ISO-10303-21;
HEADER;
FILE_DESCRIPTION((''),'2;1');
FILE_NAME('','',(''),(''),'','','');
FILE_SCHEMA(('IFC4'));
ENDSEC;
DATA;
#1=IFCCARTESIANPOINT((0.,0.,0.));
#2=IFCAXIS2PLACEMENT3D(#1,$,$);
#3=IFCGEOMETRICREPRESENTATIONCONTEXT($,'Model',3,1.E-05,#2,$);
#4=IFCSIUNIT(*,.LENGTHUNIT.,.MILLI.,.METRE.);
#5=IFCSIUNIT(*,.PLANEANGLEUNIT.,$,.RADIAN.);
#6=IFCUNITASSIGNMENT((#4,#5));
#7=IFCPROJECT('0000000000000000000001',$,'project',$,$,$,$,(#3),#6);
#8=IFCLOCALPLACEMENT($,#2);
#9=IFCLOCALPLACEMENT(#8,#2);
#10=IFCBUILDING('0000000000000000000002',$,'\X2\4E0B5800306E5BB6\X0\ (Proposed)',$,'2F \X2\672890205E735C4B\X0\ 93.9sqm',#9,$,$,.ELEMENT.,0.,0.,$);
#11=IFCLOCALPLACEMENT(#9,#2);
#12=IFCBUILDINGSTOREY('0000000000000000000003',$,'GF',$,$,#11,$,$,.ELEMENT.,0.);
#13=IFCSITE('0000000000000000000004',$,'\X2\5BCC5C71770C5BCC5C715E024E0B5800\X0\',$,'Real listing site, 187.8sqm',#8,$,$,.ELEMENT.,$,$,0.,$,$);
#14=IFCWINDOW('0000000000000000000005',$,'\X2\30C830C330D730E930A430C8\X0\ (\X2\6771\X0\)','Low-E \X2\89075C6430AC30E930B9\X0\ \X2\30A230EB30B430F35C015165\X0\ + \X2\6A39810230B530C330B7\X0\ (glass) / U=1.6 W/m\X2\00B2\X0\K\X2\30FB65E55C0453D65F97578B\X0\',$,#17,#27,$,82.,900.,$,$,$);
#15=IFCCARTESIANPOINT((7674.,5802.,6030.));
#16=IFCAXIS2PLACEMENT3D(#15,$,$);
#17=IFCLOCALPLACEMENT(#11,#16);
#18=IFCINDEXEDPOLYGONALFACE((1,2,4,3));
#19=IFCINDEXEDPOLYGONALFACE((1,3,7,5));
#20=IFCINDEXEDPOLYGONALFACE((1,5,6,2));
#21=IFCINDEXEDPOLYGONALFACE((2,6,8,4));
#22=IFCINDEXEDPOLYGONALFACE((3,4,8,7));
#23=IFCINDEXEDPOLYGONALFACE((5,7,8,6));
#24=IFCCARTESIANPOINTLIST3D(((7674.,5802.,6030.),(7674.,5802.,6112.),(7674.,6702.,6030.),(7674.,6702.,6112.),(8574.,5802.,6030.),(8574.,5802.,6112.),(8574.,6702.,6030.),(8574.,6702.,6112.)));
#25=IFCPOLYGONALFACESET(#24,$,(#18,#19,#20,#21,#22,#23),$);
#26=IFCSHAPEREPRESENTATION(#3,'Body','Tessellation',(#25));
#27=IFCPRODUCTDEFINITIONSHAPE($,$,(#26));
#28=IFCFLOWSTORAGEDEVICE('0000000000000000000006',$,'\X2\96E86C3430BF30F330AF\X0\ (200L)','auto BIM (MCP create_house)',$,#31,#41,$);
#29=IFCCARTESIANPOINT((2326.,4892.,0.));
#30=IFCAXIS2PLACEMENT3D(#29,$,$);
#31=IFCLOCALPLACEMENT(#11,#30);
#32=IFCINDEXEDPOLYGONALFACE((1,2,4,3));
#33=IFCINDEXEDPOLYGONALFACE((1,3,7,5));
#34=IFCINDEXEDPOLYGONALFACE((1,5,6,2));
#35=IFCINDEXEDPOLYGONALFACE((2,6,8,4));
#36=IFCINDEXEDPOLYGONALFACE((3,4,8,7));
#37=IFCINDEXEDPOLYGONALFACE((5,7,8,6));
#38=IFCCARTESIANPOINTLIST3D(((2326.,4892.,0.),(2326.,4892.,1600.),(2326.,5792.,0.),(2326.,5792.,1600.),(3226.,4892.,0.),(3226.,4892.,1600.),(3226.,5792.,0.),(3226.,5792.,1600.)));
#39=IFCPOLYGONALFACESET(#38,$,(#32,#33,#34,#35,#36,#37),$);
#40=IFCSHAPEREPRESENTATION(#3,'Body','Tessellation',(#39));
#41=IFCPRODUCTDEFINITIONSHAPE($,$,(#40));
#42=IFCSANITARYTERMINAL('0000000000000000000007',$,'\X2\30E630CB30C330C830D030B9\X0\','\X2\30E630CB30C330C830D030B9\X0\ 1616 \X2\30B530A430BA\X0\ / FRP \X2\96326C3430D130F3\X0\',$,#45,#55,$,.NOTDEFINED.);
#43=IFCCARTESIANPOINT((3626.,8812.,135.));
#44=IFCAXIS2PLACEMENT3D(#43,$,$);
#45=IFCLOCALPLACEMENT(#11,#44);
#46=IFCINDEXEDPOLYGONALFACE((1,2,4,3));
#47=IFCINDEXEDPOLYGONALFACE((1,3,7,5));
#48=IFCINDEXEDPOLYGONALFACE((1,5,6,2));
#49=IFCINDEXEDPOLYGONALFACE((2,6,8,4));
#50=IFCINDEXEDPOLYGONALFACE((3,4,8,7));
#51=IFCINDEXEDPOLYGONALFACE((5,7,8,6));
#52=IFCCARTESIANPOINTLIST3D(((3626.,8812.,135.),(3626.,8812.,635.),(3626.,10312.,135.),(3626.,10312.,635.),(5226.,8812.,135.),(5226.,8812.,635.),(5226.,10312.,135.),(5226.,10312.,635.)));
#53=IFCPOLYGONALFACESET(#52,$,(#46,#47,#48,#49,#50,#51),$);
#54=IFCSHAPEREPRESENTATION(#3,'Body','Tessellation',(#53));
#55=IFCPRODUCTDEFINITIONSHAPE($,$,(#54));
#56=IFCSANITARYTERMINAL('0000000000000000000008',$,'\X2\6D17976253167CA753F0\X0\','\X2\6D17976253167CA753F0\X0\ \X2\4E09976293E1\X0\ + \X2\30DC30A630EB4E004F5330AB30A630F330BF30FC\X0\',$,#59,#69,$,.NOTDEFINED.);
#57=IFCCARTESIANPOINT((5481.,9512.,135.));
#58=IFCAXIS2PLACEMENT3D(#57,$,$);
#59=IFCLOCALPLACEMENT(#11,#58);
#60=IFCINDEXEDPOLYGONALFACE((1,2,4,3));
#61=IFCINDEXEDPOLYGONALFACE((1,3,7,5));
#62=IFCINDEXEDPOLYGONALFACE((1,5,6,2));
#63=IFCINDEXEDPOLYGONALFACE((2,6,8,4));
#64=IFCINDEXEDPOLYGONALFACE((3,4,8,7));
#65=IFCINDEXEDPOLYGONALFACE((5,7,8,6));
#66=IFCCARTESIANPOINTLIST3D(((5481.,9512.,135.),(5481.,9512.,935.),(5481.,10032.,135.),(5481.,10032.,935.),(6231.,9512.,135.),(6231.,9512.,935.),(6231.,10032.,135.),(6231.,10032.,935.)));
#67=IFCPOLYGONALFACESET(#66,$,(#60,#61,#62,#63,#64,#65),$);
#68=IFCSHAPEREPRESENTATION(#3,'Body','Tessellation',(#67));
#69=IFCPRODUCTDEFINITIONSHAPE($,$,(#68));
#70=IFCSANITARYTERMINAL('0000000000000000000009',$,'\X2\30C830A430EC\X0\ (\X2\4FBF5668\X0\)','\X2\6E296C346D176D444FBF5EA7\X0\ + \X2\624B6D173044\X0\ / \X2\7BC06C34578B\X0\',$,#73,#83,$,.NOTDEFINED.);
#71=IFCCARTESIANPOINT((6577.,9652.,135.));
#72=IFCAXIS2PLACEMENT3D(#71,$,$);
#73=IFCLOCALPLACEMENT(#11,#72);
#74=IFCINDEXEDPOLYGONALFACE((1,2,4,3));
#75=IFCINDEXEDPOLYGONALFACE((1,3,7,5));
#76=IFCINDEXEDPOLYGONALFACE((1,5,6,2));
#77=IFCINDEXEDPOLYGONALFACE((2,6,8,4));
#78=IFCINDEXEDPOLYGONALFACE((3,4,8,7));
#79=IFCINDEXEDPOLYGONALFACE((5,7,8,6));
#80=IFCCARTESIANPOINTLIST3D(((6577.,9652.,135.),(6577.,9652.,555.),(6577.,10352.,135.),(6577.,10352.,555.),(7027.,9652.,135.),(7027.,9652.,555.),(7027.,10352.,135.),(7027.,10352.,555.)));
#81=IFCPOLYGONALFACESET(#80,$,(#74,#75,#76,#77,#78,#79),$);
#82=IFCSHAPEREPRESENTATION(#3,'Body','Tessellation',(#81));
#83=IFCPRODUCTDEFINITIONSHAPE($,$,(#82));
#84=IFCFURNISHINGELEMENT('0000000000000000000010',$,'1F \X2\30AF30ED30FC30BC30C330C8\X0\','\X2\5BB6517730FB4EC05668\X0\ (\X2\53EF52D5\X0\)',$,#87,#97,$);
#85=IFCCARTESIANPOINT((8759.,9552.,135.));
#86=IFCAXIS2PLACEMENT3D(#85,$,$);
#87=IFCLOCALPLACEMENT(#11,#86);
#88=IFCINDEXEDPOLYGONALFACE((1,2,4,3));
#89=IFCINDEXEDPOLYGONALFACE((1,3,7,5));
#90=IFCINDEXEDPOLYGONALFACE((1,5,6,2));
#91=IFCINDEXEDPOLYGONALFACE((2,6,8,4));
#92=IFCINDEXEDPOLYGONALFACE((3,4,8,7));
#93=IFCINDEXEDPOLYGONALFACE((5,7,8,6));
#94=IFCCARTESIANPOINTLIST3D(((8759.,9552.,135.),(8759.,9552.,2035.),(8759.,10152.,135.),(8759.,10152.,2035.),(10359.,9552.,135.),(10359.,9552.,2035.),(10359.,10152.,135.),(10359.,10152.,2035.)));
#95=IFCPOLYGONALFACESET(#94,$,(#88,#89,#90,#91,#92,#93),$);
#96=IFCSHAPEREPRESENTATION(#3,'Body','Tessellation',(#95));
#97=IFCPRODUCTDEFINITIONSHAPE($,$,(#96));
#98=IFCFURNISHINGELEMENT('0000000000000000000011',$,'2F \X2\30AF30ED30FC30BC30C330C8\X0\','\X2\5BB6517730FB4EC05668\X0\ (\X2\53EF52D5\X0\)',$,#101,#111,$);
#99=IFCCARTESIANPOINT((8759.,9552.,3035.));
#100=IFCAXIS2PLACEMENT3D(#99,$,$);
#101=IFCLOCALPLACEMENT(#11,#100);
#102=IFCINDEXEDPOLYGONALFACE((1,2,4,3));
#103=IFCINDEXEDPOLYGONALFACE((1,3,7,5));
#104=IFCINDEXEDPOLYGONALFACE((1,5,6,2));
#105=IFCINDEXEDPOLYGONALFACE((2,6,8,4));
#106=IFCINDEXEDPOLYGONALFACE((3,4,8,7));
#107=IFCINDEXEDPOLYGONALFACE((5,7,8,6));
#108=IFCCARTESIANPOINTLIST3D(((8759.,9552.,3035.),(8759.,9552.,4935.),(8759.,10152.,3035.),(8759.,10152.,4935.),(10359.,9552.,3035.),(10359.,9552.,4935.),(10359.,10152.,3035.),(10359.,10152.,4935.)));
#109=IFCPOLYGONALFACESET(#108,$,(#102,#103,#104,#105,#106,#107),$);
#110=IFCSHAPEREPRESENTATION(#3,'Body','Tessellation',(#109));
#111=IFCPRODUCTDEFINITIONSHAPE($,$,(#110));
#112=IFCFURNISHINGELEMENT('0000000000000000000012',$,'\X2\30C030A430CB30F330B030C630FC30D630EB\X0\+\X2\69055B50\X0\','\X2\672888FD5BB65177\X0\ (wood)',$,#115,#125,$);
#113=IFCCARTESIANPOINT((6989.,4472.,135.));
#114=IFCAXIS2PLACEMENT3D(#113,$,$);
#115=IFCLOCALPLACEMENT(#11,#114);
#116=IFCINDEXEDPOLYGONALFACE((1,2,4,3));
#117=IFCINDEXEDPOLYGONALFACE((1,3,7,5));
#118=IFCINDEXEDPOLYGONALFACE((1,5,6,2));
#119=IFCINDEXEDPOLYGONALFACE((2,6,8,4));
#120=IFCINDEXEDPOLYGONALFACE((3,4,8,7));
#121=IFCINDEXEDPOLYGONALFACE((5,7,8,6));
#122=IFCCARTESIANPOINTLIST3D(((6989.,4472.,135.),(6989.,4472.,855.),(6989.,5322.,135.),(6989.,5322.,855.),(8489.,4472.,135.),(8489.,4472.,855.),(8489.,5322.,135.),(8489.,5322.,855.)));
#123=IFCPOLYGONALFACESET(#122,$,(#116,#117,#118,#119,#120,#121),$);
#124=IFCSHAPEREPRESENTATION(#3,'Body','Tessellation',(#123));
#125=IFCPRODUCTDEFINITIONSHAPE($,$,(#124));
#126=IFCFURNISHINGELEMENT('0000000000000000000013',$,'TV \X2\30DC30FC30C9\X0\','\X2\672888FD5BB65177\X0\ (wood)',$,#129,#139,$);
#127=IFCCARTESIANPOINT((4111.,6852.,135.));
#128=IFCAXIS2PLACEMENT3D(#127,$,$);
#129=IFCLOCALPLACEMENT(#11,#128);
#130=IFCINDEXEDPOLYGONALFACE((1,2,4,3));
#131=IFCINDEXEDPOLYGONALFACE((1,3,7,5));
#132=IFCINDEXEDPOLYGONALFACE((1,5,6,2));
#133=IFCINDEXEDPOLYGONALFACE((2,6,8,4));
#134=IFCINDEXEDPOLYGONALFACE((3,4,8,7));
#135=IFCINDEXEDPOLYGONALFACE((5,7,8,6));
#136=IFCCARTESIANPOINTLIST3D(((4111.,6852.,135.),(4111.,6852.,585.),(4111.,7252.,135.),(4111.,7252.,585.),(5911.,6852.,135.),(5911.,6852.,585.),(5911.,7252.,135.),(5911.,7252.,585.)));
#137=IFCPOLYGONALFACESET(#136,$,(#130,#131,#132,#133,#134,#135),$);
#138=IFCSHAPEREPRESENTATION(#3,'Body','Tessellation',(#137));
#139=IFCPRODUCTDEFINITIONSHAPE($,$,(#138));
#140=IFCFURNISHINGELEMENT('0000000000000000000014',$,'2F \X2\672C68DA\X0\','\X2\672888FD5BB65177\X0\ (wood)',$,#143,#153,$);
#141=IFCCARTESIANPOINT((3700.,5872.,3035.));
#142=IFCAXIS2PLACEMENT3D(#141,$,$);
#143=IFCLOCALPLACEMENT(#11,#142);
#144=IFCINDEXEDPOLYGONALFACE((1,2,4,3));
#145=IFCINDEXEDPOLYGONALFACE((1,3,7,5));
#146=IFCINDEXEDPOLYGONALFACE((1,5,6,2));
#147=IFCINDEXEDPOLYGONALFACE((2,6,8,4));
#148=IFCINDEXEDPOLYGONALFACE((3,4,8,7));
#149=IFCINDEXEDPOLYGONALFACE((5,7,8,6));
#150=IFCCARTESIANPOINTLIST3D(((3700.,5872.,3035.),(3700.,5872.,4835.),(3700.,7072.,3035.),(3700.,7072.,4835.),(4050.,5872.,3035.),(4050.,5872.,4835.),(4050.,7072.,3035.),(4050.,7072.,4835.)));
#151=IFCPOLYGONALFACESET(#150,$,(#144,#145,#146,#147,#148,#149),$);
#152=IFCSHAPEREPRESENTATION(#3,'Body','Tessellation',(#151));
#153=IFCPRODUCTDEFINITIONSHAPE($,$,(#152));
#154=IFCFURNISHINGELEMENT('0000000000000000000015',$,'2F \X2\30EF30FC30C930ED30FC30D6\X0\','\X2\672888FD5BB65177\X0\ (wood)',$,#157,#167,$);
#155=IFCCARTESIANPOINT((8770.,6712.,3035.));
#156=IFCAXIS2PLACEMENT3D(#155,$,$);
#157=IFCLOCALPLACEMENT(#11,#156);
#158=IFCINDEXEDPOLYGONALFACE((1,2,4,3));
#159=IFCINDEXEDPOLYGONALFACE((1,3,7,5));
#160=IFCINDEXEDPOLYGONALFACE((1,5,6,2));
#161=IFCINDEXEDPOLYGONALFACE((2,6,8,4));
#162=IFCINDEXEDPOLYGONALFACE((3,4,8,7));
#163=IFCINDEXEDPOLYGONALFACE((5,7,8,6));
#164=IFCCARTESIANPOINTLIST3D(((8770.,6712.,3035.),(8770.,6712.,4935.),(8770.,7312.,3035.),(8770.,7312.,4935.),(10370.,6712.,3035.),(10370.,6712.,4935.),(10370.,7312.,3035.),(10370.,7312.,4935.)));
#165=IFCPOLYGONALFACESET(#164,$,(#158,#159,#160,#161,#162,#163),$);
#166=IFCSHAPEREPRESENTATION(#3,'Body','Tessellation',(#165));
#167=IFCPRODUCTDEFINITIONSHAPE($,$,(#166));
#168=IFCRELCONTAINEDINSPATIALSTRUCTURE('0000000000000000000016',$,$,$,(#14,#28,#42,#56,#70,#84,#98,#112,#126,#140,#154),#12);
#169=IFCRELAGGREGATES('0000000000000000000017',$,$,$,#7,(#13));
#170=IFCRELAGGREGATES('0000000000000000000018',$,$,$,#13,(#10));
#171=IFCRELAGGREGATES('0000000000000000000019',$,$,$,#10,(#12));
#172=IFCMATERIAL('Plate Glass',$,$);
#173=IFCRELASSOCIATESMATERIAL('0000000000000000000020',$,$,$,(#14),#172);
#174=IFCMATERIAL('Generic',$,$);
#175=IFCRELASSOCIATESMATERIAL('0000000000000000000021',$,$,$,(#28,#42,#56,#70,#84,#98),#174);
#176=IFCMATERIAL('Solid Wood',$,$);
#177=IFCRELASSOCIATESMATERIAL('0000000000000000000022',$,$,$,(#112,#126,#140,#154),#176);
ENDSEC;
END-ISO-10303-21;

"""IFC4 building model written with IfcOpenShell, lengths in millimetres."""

from ifc_helpers import new_model, si_unit, frame, frame_2d, origin, place, context, project, spatial, rectangle, extrude, material, element, save


model = new_model("IFC4")

# Units and contexts
model_context = context("Model", 3, precision=1e-05, world=origin())
ifc_project = project(units=[si_unit("LENGTHUNIT", "METRE", prefix="MILLI"), si_unit("PLANEANGLEUNIT", "RADIAN")], contexts=[model_context])

# Site, building, storey
site_placement = place(None, origin())
site = spatial("IfcSite", under=ifc_project, at=site_placement, Name="富山県富山市下堀", ObjectType="Real listing site, 187.8sqm", CompositionType="ELEMENT", RefElevation=0.0)
building_placement = place(site_placement, origin())
building = spatial("IfcBuilding", under=site, at=building_placement, Name="下堀の家 (Proposed)", ObjectType="2F 木造平屋 93.9sqm", CompositionType="ELEMENT", ElevationOfRefHeight=0.0, ElevationOfTerrain=0.0)
storey_placement = place(building_placement, origin())
storey = spatial("IfcBuildingStorey", under=building, at=storey_placement, Name="GF", CompositionType="ELEMENT", Elevation=0.0)

# Shared definitions
ifc_material_1 = material(Name="Solid Wood")
ifc_material_2 = material(Name="Plate Glass")

# Window
window_1_placement = place(storey_placement, frame((7674.0, 5802.0, 6030.0)))
element("IfcWindow", 1, at=window_1_placement, inside=storey, material=ifc_material_2, Name="トップライト (東)", Description="Low-E 複層ガラス アルゴン封入 + 樹脂サッシ (glass) / U=1.6 W/m²K・日射取得型", OverallHeight=82.0, OverallWidth=900.0, context=model_context, shape_type="SweptSolid", body=[
    extrude(rectangle(XDim=900.0, YDim=900.0, at=frame_2d((450.0, 450.0))), frame((7674.0, 5802.0, 6030.0)), (0.0, 0.0, 1.0), 82.0),
])

# Flow storage device
ifc_material_3 = material(Name="Generic")
flow_storage_device_placement = place(storey_placement, frame((2326.0, 4892.0, 0.0)))
element("IfcFlowStorageDevice", 2, at=flow_storage_device_placement, inside=storey, material=ifc_material_3, Name="雨水タンク (200L)", Description="auto BIM (MCP create_house)", context=model_context, shape_type="SweptSolid", body=[
    extrude(rectangle(XDim=900.0, YDim=900.0, at=frame_2d((450.0, 450.0))), frame((2326.0, 4892.0, 0.0)), (0.0, 0.0, 1.0), 1600.0),
])

# Sanitary terminals
sanitary_terminal_1_placement = place(storey_placement, frame((3626.0, 8812.0, 135.0)))
element("IfcSanitaryTerminal", 3, at=sanitary_terminal_1_placement, inside=storey, material=ifc_material_3, Name="ユニットバス", Description="ユニットバス 1616 サイズ / FRP 防水パン", PredefinedType="NOTDEFINED", context=model_context, shape_type="SweptSolid", body=[
    extrude(rectangle(XDim=1600.0, YDim=1500.0, at=frame_2d((800.0, 750.0))), frame((3626.0, 8812.0, 135.0)), (0.0, 0.0, 1.0), 500.0),
])
sanitary_terminal_2_placement = place(storey_placement, frame((5481.0, 9512.0, 135.0)))
element("IfcSanitaryTerminal", 4, at=sanitary_terminal_2_placement, inside=storey, material=ifc_material_3, Name="洗面化粧台", Description="洗面化粧台 三面鏡 + ボウル一体カウンター", PredefinedType="NOTDEFINED", context=model_context, shape_type="SweptSolid", body=[
    extrude(rectangle(XDim=750.0, YDim=520.0, at=frame_2d((375.0, 260.0))), frame((5481.0, 9512.0, 135.0)), (0.0, 0.0, 1.0), 800.0),
])
sanitary_terminal_3_placement = place(storey_placement, frame((6577.0, 9652.0, 135.0)))
element("IfcSanitaryTerminal", 5, at=sanitary_terminal_3_placement, inside=storey, material=ifc_material_3, Name="トイレ (便器)", Description="温水洗浄便座 + 手洗い / 節水型", PredefinedType="NOTDEFINED", context=model_context, shape_type="SweptSolid", body=[
    extrude(rectangle(XDim=450.0, YDim=700.0, at=frame_2d((225.0, 350.0))), frame((6577.0, 9652.0, 135.0)), (0.0, 0.0, 1.0), 420.0),
])

# Furnishing elements
furnishing_1_placement = place(storey_placement, frame((8759.0, 9552.0, 135.0)))
element("IfcFurnishingElement", 6, at=furnishing_1_placement, inside=storey, material=ifc_material_3, Name="1F クローゼット", Description="家具・什器 (可動)", context=model_context, shape_type="SweptSolid", body=[
    extrude(rectangle(XDim=1600.0, YDim=600.0, at=frame_2d((800.0, 300.0))), frame((8759.0, 9552.0, 135.0)), (0.0, 0.0, 1.0), 1900.0),
])
furnishing_2_placement = place(storey_placement, frame((8759.0, 9552.0, 3035.0)))
element("IfcFurnishingElement", 7, at=furnishing_2_placement, inside=storey, material=ifc_material_3, Name="2F クローゼット", Description="家具・什器 (可動)", context=model_context, shape_type="SweptSolid", body=[
    extrude(rectangle(XDim=1600.0, YDim=600.0, at=frame_2d((800.0, 300.0))), frame((8759.0, 9552.0, 3035.0)), (0.0, 0.0, 1.0), 1900.0),
])
furnishing_3_placement = place(storey_placement, frame((6989.0, 4472.0, 135.0)))
element("IfcFurnishingElement", 8, at=furnishing_3_placement, inside=storey, material=ifc_material_1, Name="ダイニングテーブル+椅子", Description="木製家具 (wood)", context=model_context, shape_type="SweptSolid", body=[
    extrude(rectangle(XDim=1500.0, YDim=850.0, at=frame_2d((750.0, 425.0))), frame((6989.0, 4472.0, 135.0)), (0.0, 0.0, 1.0), 720.0),
])
furnishing_4_placement = place(storey_placement, frame((4111.0, 6852.0, 135.0)))
element("IfcFurnishingElement", 9, at=furnishing_4_placement, inside=storey, material=ifc_material_1, Name="TV ボード", Description="木製家具 (wood)", context=model_context, shape_type="SweptSolid", body=[
    extrude(rectangle(XDim=1800.0, YDim=400.0, at=frame_2d((900.0, 200.0))), frame((4111.0, 6852.0, 135.0)), (0.0, 0.0, 1.0), 450.0),
])
furnishing_5_placement = place(storey_placement, frame((3700.0, 5872.0, 3035.0)))
element("IfcFurnishingElement", 10, at=furnishing_5_placement, inside=storey, material=ifc_material_1, Name="2F 本棚", Description="木製家具 (wood)", context=model_context, shape_type="SweptSolid", body=[
    extrude(rectangle(XDim=350.0, YDim=1200.0, at=frame_2d((175.0, 600.0))), frame((3700.0, 5872.0, 3035.0)), (0.0, 0.0, 1.0), 1800.0),
])
furnishing_6_placement = place(storey_placement, frame((8770.0, 6712.0, 3035.0)))
element("IfcFurnishingElement", 11, at=furnishing_6_placement, inside=storey, material=ifc_material_1, Name="2F ワードローブ", Description="木製家具 (wood)", context=model_context, shape_type="SweptSolid", body=[
    extrude(rectangle(XDim=1600.0, YDim=600.0, at=frame_2d((800.0, 300.0))), frame((8770.0, 6712.0, 3035.0)), (0.0, 0.0, 1.0), 1900.0),
])

save(model, "model.ifc")
